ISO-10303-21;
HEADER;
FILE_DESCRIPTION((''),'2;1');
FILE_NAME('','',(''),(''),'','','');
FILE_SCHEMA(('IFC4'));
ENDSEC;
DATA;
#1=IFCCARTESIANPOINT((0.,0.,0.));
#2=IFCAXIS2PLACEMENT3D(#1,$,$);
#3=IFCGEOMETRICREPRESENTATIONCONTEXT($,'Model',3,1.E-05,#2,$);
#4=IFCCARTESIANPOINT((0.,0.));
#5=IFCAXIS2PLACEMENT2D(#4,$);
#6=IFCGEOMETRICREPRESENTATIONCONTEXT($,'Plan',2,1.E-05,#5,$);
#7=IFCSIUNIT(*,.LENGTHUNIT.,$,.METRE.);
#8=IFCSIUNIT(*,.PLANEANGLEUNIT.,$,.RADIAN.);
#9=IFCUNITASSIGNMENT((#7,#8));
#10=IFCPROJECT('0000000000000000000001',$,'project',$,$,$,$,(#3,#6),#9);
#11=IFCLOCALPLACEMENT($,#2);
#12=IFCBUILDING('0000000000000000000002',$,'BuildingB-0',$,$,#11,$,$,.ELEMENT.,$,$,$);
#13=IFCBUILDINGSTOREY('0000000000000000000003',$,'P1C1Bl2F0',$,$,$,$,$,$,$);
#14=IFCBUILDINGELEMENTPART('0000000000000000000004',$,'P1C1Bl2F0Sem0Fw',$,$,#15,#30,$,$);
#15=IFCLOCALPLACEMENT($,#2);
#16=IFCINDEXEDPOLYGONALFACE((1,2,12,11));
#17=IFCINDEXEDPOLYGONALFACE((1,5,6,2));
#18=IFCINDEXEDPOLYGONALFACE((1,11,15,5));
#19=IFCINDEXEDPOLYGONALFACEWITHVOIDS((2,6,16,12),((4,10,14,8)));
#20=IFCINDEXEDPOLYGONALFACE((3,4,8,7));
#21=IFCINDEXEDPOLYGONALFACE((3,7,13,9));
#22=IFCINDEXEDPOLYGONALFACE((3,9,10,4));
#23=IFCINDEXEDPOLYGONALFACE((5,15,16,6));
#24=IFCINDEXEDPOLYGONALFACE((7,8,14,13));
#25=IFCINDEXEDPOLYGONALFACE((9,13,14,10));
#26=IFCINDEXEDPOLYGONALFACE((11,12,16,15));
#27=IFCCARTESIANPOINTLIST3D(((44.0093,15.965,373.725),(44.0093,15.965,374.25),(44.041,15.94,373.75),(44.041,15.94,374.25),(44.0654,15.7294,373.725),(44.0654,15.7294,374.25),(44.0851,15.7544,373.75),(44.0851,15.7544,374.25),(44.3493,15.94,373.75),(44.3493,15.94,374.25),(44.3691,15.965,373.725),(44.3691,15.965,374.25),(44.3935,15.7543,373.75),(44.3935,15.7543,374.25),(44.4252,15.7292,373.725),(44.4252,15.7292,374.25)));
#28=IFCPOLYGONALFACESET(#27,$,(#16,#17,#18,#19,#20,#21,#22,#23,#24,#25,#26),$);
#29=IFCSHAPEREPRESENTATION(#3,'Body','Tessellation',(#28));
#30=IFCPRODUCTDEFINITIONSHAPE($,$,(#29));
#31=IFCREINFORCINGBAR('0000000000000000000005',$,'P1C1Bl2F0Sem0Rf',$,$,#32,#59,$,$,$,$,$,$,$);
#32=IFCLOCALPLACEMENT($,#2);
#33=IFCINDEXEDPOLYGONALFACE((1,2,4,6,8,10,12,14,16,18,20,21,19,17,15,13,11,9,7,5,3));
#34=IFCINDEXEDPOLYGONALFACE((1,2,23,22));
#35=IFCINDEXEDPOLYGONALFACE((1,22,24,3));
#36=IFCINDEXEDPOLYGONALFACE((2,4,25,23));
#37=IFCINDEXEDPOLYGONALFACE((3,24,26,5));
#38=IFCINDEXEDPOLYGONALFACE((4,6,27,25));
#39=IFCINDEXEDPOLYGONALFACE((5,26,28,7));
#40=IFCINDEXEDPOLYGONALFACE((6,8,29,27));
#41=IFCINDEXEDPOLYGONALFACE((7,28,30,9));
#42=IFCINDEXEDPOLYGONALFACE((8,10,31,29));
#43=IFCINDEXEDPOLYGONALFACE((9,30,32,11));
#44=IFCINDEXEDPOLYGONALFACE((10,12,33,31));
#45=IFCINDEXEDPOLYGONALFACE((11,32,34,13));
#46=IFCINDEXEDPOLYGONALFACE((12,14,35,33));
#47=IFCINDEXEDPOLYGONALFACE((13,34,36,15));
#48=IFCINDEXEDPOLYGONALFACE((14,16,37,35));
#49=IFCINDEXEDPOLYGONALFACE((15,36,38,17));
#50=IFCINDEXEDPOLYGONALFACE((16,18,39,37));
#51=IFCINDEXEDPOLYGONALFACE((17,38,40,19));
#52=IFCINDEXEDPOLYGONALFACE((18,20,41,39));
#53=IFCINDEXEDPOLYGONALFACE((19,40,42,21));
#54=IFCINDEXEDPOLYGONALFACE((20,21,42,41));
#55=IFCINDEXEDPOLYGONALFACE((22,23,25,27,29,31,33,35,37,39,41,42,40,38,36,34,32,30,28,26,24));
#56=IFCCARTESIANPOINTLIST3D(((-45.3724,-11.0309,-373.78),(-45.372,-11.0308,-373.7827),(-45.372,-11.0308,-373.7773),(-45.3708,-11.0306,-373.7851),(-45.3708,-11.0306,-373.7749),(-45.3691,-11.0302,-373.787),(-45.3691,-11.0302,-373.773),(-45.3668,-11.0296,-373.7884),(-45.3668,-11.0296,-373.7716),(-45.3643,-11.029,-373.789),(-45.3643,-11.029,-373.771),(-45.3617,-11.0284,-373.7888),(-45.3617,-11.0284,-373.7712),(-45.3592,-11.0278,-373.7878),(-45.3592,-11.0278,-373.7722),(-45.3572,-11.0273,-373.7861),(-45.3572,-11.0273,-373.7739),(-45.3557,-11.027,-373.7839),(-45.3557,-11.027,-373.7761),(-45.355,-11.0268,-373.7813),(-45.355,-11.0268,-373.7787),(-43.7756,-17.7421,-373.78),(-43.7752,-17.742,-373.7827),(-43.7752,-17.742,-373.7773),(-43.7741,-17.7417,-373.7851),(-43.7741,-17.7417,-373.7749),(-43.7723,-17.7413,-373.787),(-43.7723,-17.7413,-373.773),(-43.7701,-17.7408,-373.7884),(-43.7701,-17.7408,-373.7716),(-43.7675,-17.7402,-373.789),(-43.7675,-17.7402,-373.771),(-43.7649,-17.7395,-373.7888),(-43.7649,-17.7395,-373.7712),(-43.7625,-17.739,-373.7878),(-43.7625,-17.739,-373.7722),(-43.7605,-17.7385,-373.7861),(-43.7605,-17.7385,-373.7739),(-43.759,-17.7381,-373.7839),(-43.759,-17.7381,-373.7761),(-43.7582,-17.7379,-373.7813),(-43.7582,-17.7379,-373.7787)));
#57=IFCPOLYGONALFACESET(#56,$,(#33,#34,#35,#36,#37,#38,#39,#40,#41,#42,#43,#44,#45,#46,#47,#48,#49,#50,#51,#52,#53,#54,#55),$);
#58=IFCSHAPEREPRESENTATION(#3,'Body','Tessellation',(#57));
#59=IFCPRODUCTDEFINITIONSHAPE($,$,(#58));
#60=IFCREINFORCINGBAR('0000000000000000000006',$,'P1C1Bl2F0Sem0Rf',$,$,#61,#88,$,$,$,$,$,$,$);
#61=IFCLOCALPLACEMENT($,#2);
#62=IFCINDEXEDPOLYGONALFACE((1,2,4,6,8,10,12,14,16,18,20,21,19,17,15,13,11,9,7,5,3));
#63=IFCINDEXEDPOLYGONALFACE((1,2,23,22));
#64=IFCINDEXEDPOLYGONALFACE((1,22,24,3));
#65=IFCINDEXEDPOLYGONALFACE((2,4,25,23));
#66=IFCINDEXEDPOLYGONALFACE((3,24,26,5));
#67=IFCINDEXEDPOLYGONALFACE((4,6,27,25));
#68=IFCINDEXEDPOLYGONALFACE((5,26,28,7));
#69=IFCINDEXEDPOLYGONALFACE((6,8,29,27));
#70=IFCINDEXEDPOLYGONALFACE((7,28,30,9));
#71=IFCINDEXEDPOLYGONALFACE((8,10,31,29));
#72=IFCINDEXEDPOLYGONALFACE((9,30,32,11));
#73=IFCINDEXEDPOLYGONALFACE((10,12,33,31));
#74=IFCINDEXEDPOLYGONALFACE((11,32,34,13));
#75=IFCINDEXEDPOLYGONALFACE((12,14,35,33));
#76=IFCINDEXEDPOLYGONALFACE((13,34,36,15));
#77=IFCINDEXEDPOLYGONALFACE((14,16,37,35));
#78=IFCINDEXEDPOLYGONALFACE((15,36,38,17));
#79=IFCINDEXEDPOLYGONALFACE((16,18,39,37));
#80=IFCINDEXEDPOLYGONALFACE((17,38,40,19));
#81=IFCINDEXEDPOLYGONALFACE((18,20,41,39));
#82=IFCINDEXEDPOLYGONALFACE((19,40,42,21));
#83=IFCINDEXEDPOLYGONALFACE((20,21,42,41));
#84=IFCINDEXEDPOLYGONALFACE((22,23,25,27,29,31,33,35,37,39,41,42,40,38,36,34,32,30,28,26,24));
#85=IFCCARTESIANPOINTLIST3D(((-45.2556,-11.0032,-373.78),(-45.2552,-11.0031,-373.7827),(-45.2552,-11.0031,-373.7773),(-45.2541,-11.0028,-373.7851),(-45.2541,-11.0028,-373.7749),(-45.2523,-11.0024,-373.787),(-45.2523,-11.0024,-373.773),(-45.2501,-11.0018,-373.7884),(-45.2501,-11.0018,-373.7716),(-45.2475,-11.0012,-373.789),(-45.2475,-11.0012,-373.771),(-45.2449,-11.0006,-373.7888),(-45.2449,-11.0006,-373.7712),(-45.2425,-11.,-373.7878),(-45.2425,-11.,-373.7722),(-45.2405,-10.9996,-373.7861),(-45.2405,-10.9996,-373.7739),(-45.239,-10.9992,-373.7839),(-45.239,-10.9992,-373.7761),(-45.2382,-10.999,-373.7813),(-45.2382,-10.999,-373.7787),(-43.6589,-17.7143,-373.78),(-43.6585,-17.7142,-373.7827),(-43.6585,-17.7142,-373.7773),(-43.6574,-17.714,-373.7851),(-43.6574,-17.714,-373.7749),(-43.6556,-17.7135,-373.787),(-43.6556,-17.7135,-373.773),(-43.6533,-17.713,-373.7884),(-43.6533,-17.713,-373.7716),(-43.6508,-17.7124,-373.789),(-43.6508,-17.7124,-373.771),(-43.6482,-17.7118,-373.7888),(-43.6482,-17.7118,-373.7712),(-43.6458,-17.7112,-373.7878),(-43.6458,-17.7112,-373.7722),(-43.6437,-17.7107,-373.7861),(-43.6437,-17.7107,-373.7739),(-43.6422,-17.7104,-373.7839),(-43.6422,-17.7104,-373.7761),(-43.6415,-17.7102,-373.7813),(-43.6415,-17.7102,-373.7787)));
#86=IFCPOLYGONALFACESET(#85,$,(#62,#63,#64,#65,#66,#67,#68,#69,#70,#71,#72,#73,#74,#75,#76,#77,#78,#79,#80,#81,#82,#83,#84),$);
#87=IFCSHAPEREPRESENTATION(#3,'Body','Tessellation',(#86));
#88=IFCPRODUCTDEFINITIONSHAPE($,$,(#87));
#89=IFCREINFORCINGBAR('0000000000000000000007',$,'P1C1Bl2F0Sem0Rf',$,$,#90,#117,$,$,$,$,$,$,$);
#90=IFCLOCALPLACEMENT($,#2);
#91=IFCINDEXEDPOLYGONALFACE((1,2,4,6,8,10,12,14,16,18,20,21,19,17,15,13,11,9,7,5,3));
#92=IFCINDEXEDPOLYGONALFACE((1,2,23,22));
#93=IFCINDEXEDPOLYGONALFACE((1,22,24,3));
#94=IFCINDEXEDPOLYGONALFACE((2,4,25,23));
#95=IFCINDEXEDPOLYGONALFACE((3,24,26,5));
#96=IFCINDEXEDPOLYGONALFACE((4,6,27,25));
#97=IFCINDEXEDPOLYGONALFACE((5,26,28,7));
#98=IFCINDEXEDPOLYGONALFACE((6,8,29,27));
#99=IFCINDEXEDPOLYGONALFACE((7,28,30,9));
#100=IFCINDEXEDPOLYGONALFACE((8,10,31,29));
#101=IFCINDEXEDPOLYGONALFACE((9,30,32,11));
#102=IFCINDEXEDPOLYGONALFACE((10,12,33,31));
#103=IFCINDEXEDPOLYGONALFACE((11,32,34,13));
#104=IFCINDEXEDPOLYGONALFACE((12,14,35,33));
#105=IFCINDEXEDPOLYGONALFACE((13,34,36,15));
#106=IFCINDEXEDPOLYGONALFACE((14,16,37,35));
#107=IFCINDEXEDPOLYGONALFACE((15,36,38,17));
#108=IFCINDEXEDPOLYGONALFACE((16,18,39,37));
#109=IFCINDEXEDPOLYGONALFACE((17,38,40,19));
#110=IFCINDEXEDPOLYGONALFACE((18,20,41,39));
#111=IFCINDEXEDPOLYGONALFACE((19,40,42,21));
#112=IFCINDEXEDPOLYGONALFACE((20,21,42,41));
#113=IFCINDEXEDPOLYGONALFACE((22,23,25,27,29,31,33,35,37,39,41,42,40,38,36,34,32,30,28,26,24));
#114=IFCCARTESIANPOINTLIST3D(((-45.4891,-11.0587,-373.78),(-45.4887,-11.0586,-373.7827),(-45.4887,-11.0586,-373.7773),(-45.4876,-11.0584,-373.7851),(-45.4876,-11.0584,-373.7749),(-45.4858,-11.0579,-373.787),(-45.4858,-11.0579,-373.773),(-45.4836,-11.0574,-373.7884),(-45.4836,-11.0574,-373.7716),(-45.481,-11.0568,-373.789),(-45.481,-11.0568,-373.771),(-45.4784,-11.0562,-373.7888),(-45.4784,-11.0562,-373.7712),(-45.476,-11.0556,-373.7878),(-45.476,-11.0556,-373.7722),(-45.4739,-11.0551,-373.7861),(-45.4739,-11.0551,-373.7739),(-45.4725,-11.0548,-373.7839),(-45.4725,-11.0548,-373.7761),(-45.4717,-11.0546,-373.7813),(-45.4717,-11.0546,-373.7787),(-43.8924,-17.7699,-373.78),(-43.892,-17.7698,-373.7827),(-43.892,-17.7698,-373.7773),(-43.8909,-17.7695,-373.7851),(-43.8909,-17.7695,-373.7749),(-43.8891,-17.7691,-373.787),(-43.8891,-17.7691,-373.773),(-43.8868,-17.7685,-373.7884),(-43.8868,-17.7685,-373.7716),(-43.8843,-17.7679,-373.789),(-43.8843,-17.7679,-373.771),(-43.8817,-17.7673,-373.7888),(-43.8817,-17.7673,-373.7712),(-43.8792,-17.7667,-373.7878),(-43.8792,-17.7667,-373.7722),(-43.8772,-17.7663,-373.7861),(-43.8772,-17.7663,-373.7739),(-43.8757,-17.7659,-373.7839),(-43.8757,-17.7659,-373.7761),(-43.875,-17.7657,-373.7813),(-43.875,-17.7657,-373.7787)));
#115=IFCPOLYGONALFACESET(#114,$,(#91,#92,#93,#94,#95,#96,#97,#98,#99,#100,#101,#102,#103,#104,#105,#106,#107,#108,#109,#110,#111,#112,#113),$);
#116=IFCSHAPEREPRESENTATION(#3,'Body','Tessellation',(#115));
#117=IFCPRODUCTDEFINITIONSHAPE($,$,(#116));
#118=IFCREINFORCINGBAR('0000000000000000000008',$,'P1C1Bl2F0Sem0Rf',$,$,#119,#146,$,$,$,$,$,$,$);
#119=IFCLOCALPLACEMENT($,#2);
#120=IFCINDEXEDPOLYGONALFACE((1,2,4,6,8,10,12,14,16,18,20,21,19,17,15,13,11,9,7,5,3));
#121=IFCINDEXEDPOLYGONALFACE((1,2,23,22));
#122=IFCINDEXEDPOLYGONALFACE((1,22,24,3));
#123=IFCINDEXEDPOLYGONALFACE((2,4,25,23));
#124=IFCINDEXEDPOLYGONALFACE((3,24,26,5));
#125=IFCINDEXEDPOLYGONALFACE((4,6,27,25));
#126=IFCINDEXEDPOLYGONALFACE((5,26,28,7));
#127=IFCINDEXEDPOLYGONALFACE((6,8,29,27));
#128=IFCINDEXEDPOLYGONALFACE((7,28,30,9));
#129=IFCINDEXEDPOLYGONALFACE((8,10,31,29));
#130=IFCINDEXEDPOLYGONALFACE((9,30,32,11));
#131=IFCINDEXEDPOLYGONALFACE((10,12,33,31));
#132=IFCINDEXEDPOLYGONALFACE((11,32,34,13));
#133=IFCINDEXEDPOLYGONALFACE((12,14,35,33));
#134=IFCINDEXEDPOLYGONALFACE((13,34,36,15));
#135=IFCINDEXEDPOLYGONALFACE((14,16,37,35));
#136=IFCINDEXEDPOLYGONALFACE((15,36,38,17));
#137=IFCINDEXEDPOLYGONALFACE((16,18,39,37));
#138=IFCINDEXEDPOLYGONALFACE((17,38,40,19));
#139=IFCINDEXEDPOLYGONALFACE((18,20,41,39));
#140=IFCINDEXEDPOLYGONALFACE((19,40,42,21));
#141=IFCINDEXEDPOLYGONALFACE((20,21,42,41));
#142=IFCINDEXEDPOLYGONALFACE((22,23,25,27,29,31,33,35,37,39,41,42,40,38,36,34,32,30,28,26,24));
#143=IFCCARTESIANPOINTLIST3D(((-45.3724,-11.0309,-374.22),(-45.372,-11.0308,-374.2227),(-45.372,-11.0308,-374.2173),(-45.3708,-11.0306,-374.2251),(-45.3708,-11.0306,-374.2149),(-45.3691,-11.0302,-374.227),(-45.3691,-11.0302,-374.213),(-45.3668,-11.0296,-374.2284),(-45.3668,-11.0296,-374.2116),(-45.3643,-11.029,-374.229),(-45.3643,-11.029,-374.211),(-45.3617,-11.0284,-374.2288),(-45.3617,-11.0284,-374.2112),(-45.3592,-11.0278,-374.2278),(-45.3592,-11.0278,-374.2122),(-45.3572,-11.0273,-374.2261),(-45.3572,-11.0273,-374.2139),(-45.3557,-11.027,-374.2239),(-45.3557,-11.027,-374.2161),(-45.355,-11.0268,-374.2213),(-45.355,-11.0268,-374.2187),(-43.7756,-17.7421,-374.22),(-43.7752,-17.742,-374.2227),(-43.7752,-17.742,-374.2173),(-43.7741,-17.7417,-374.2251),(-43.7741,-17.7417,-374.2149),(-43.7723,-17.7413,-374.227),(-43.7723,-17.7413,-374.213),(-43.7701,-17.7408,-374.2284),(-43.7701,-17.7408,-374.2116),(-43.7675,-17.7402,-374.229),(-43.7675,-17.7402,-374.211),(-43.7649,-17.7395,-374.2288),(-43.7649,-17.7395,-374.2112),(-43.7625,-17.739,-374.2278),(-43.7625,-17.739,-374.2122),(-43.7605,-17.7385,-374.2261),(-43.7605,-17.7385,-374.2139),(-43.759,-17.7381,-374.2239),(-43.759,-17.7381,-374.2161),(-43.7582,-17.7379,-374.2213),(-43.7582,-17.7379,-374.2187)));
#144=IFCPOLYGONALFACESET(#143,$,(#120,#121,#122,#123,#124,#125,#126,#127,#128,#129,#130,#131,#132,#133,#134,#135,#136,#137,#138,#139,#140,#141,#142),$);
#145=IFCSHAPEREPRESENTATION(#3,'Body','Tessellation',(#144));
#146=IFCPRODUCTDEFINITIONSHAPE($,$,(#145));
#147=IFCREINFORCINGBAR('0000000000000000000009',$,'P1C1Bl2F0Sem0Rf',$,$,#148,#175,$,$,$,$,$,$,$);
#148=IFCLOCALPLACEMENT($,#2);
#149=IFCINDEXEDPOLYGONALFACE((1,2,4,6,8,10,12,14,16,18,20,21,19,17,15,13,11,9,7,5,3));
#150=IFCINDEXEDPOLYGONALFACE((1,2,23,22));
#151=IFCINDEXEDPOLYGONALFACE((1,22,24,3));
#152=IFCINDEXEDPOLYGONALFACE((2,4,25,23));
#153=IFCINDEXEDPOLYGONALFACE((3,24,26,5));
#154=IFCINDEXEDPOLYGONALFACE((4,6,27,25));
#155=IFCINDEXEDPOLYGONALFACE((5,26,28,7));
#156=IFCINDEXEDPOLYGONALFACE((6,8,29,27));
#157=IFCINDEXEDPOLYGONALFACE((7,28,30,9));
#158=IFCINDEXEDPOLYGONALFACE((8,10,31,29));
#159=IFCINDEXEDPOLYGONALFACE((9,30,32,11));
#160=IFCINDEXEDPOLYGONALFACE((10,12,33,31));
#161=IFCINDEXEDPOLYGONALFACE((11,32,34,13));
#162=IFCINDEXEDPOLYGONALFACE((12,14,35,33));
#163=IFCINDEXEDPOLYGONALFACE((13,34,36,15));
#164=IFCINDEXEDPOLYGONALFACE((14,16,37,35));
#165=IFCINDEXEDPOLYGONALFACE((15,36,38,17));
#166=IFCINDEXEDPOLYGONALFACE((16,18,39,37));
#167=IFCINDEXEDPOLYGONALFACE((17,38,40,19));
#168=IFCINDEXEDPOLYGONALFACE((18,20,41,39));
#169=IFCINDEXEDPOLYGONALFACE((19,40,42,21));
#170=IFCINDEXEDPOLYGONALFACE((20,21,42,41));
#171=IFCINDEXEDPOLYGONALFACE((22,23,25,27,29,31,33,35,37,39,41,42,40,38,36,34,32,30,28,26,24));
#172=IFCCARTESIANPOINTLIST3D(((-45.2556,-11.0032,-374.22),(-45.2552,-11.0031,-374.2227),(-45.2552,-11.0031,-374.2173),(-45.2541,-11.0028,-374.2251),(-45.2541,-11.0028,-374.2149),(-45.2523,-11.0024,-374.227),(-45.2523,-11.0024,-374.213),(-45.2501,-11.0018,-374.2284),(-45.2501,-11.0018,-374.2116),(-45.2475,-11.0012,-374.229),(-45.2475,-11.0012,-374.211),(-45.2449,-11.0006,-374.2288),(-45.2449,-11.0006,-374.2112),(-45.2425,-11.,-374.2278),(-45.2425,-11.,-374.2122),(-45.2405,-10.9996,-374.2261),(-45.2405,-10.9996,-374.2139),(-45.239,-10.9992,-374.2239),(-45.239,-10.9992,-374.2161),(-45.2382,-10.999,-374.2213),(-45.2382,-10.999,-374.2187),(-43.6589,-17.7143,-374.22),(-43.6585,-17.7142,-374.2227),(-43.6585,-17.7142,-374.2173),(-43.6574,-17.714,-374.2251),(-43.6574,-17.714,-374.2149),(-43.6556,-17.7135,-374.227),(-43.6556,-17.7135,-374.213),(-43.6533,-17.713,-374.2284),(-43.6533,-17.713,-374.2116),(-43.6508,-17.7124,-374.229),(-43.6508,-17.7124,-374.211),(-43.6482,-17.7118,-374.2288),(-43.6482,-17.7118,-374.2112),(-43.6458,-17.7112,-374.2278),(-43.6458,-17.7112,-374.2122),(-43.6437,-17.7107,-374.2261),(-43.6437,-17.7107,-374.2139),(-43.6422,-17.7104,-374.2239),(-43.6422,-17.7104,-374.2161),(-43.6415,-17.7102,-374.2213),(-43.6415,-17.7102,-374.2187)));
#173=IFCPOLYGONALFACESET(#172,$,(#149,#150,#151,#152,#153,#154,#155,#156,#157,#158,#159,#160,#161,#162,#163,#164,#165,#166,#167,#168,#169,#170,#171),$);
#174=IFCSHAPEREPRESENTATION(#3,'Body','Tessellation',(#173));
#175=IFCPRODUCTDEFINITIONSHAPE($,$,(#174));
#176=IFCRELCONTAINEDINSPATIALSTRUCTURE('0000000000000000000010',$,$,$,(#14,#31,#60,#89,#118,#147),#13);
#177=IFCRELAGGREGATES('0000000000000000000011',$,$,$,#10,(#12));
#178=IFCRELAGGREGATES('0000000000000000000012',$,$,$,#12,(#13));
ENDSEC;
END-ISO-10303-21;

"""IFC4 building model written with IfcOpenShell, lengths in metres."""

from ifc_helpers import new_model, entity, si_unit, origin, origin_2d, place, context, project, spatial, polyline, outline, extrude, element, save


model = new_model("IFC4")

# Units and contexts
model_context = context("Model", 3, precision=1e-05, world=origin())
plan_context = context("Plan", 2, precision=1e-05, world=origin_2d())
ifc_project = project(units=[si_unit("LENGTHUNIT", "METRE"), si_unit("PLANEANGLEUNIT", "RADIAN")], contexts=[model_context, plan_context])

# Building, storey
building_placement = place(None, origin())
building = spatial("IfcBuilding", under=ifc_project, at=building_placement, Name="BuildingB-0", CompositionType="ELEMENT")
storey = spatial("IfcBuildingStorey", under=building, Name="P1C1Bl2F0")

# Building element part, opening
building_element_part_1 = element("IfcBuildingElementPart", 1, inside=storey, Name="P1C1Bl2F0Sem0Fw", context=model_context, shape_type="SweptSolid", body=[
    extrude(outline(polyline([(44.0654, 15.7294, 373.725), (44.0093, 15.965, 373.725), (44.3691, 15.965, 373.725), (44.4252, 15.7292, 373.725), (44.0654, 15.7294, 373.725)])), None, (0.0, 0.0, 1.0), 0.525),
])
element("IfcOpeningElement", 2, inside=storey, cuts=building_element_part_1, context=model_context, shape_type="SweptSolid", body=[
    extrude(outline(polyline([(44.0851, 15.7544, 373.75), (44.041, 15.94, 373.75), (44.3493, 15.94, 373.75), (44.3935, 15.7543, 373.75), (44.0851, 15.7544, 373.75)])), None, (0.0, 0.0, 1.0), 0.5),
])

# Reinforcing bars
element("IfcReinforcingBar", 3, inside=storey, Name="P1C1Bl2F0Sem0Rf", context=model_context, shape_type="SweptSolid", body=[
    entity("IfcSurfaceCurveSweptAreaSolid", entity("IfcCircleProfileDef", "AREA", None, None, 0.009), None, entity("IfcPolyline", [entity("IfcCartesianPoint", [43.7669, 17.74, 373.78]), entity("IfcCartesianPoint", [45.3636, 11.0289, 373.78])]), None, None, entity("IfcPlane", entity("IfcAxis2Placement3D", entity("IfcCartesianPoint", [43.7669, 17.74, 373.78]), entity("IfcDirection", [0.0, 0.0, 1.0]), entity("IfcDirection", [1.0, 0.0, 0.0])))),
])
element("IfcReinforcingBar", 4, inside=storey, Name="P1C1Bl2F0Sem0Rf", context=model_context, shape_type="SweptSolid", body=[
    entity("IfcSurfaceCurveSweptAreaSolid", entity("IfcCircleProfileDef", "AREA", None, None, 0.009), None, entity("IfcPolyline", [entity("IfcCartesianPoint", [43.6501, 17.7122, 373.78]), entity("IfcCartesianPoint", [45.2469, 11.0011, 373.78])]), None, None, entity("IfcPlane", entity("IfcAxis2Placement3D", entity("IfcCartesianPoint", [43.6501, 17.7122, 373.78]), entity("IfcDirection", [0.0, 0.0, 1.0]), entity("IfcDirection", [1.0, 0.0, 0.0])))),
])
element("IfcReinforcingBar", 5, inside=storey, Name="P1C1Bl2F0Sem0Rf", context=model_context, shape_type="SweptSolid", body=[
    entity("IfcSurfaceCurveSweptAreaSolid", entity("IfcCircleProfileDef", "AREA", None, None, 0.009), None, entity("IfcPolyline", [entity("IfcCartesianPoint", [43.8836, 17.7678, 373.78]), entity("IfcCartesianPoint", [45.4804, 11.0566, 373.78])]), None, None, entity("IfcPlane", entity("IfcAxis2Placement3D", entity("IfcCartesianPoint", [43.8836, 17.7678, 373.78]), entity("IfcDirection", [0.0, 0.0, 1.0]), entity("IfcDirection", [1.0, 0.0, 0.0])))),
])
element("IfcReinforcingBar", 6, inside=storey, Name="P1C1Bl2F0Sem0Rf", context=model_context, shape_type="SweptSolid", body=[
    entity("IfcSurfaceCurveSweptAreaSolid", entity("IfcCircleProfileDef", "AREA", None, None, 0.009), None, entity("IfcPolyline", [entity("IfcCartesianPoint", [43.7669, 17.74, 374.22]), entity("IfcCartesianPoint", [45.3636, 11.0289, 374.22])]), None, None, entity("IfcPlane", entity("IfcAxis2Placement3D", entity("IfcCartesianPoint", [43.7669, 17.74, 374.22]), entity("IfcDirection", [0.0, 0.0, 1.0]), entity("IfcDirection", [1.0, 0.0, 0.0])))),
])
element("IfcReinforcingBar", 7, inside=storey, Name="P1C1Bl2F0Sem0Rf", context=model_context, shape_type="SweptSolid", body=[
    entity("IfcSurfaceCurveSweptAreaSolid", entity("IfcCircleProfileDef", "AREA", None, None, 0.009), None, entity("IfcPolyline", [entity("IfcCartesianPoint", [43.6501, 17.7122, 374.22]), entity("IfcCartesianPoint", [45.2469, 11.0011, 374.22])]), None, None, entity("IfcPlane", entity("IfcAxis2Placement3D", entity("IfcCartesianPoint", [43.6501, 17.7122, 374.22]), entity("IfcDirection", [0.0, 0.0, 1.0]), entity("IfcDirection", [1.0, 0.0, 0.0])))),
])

save(model, "model.ifc")
